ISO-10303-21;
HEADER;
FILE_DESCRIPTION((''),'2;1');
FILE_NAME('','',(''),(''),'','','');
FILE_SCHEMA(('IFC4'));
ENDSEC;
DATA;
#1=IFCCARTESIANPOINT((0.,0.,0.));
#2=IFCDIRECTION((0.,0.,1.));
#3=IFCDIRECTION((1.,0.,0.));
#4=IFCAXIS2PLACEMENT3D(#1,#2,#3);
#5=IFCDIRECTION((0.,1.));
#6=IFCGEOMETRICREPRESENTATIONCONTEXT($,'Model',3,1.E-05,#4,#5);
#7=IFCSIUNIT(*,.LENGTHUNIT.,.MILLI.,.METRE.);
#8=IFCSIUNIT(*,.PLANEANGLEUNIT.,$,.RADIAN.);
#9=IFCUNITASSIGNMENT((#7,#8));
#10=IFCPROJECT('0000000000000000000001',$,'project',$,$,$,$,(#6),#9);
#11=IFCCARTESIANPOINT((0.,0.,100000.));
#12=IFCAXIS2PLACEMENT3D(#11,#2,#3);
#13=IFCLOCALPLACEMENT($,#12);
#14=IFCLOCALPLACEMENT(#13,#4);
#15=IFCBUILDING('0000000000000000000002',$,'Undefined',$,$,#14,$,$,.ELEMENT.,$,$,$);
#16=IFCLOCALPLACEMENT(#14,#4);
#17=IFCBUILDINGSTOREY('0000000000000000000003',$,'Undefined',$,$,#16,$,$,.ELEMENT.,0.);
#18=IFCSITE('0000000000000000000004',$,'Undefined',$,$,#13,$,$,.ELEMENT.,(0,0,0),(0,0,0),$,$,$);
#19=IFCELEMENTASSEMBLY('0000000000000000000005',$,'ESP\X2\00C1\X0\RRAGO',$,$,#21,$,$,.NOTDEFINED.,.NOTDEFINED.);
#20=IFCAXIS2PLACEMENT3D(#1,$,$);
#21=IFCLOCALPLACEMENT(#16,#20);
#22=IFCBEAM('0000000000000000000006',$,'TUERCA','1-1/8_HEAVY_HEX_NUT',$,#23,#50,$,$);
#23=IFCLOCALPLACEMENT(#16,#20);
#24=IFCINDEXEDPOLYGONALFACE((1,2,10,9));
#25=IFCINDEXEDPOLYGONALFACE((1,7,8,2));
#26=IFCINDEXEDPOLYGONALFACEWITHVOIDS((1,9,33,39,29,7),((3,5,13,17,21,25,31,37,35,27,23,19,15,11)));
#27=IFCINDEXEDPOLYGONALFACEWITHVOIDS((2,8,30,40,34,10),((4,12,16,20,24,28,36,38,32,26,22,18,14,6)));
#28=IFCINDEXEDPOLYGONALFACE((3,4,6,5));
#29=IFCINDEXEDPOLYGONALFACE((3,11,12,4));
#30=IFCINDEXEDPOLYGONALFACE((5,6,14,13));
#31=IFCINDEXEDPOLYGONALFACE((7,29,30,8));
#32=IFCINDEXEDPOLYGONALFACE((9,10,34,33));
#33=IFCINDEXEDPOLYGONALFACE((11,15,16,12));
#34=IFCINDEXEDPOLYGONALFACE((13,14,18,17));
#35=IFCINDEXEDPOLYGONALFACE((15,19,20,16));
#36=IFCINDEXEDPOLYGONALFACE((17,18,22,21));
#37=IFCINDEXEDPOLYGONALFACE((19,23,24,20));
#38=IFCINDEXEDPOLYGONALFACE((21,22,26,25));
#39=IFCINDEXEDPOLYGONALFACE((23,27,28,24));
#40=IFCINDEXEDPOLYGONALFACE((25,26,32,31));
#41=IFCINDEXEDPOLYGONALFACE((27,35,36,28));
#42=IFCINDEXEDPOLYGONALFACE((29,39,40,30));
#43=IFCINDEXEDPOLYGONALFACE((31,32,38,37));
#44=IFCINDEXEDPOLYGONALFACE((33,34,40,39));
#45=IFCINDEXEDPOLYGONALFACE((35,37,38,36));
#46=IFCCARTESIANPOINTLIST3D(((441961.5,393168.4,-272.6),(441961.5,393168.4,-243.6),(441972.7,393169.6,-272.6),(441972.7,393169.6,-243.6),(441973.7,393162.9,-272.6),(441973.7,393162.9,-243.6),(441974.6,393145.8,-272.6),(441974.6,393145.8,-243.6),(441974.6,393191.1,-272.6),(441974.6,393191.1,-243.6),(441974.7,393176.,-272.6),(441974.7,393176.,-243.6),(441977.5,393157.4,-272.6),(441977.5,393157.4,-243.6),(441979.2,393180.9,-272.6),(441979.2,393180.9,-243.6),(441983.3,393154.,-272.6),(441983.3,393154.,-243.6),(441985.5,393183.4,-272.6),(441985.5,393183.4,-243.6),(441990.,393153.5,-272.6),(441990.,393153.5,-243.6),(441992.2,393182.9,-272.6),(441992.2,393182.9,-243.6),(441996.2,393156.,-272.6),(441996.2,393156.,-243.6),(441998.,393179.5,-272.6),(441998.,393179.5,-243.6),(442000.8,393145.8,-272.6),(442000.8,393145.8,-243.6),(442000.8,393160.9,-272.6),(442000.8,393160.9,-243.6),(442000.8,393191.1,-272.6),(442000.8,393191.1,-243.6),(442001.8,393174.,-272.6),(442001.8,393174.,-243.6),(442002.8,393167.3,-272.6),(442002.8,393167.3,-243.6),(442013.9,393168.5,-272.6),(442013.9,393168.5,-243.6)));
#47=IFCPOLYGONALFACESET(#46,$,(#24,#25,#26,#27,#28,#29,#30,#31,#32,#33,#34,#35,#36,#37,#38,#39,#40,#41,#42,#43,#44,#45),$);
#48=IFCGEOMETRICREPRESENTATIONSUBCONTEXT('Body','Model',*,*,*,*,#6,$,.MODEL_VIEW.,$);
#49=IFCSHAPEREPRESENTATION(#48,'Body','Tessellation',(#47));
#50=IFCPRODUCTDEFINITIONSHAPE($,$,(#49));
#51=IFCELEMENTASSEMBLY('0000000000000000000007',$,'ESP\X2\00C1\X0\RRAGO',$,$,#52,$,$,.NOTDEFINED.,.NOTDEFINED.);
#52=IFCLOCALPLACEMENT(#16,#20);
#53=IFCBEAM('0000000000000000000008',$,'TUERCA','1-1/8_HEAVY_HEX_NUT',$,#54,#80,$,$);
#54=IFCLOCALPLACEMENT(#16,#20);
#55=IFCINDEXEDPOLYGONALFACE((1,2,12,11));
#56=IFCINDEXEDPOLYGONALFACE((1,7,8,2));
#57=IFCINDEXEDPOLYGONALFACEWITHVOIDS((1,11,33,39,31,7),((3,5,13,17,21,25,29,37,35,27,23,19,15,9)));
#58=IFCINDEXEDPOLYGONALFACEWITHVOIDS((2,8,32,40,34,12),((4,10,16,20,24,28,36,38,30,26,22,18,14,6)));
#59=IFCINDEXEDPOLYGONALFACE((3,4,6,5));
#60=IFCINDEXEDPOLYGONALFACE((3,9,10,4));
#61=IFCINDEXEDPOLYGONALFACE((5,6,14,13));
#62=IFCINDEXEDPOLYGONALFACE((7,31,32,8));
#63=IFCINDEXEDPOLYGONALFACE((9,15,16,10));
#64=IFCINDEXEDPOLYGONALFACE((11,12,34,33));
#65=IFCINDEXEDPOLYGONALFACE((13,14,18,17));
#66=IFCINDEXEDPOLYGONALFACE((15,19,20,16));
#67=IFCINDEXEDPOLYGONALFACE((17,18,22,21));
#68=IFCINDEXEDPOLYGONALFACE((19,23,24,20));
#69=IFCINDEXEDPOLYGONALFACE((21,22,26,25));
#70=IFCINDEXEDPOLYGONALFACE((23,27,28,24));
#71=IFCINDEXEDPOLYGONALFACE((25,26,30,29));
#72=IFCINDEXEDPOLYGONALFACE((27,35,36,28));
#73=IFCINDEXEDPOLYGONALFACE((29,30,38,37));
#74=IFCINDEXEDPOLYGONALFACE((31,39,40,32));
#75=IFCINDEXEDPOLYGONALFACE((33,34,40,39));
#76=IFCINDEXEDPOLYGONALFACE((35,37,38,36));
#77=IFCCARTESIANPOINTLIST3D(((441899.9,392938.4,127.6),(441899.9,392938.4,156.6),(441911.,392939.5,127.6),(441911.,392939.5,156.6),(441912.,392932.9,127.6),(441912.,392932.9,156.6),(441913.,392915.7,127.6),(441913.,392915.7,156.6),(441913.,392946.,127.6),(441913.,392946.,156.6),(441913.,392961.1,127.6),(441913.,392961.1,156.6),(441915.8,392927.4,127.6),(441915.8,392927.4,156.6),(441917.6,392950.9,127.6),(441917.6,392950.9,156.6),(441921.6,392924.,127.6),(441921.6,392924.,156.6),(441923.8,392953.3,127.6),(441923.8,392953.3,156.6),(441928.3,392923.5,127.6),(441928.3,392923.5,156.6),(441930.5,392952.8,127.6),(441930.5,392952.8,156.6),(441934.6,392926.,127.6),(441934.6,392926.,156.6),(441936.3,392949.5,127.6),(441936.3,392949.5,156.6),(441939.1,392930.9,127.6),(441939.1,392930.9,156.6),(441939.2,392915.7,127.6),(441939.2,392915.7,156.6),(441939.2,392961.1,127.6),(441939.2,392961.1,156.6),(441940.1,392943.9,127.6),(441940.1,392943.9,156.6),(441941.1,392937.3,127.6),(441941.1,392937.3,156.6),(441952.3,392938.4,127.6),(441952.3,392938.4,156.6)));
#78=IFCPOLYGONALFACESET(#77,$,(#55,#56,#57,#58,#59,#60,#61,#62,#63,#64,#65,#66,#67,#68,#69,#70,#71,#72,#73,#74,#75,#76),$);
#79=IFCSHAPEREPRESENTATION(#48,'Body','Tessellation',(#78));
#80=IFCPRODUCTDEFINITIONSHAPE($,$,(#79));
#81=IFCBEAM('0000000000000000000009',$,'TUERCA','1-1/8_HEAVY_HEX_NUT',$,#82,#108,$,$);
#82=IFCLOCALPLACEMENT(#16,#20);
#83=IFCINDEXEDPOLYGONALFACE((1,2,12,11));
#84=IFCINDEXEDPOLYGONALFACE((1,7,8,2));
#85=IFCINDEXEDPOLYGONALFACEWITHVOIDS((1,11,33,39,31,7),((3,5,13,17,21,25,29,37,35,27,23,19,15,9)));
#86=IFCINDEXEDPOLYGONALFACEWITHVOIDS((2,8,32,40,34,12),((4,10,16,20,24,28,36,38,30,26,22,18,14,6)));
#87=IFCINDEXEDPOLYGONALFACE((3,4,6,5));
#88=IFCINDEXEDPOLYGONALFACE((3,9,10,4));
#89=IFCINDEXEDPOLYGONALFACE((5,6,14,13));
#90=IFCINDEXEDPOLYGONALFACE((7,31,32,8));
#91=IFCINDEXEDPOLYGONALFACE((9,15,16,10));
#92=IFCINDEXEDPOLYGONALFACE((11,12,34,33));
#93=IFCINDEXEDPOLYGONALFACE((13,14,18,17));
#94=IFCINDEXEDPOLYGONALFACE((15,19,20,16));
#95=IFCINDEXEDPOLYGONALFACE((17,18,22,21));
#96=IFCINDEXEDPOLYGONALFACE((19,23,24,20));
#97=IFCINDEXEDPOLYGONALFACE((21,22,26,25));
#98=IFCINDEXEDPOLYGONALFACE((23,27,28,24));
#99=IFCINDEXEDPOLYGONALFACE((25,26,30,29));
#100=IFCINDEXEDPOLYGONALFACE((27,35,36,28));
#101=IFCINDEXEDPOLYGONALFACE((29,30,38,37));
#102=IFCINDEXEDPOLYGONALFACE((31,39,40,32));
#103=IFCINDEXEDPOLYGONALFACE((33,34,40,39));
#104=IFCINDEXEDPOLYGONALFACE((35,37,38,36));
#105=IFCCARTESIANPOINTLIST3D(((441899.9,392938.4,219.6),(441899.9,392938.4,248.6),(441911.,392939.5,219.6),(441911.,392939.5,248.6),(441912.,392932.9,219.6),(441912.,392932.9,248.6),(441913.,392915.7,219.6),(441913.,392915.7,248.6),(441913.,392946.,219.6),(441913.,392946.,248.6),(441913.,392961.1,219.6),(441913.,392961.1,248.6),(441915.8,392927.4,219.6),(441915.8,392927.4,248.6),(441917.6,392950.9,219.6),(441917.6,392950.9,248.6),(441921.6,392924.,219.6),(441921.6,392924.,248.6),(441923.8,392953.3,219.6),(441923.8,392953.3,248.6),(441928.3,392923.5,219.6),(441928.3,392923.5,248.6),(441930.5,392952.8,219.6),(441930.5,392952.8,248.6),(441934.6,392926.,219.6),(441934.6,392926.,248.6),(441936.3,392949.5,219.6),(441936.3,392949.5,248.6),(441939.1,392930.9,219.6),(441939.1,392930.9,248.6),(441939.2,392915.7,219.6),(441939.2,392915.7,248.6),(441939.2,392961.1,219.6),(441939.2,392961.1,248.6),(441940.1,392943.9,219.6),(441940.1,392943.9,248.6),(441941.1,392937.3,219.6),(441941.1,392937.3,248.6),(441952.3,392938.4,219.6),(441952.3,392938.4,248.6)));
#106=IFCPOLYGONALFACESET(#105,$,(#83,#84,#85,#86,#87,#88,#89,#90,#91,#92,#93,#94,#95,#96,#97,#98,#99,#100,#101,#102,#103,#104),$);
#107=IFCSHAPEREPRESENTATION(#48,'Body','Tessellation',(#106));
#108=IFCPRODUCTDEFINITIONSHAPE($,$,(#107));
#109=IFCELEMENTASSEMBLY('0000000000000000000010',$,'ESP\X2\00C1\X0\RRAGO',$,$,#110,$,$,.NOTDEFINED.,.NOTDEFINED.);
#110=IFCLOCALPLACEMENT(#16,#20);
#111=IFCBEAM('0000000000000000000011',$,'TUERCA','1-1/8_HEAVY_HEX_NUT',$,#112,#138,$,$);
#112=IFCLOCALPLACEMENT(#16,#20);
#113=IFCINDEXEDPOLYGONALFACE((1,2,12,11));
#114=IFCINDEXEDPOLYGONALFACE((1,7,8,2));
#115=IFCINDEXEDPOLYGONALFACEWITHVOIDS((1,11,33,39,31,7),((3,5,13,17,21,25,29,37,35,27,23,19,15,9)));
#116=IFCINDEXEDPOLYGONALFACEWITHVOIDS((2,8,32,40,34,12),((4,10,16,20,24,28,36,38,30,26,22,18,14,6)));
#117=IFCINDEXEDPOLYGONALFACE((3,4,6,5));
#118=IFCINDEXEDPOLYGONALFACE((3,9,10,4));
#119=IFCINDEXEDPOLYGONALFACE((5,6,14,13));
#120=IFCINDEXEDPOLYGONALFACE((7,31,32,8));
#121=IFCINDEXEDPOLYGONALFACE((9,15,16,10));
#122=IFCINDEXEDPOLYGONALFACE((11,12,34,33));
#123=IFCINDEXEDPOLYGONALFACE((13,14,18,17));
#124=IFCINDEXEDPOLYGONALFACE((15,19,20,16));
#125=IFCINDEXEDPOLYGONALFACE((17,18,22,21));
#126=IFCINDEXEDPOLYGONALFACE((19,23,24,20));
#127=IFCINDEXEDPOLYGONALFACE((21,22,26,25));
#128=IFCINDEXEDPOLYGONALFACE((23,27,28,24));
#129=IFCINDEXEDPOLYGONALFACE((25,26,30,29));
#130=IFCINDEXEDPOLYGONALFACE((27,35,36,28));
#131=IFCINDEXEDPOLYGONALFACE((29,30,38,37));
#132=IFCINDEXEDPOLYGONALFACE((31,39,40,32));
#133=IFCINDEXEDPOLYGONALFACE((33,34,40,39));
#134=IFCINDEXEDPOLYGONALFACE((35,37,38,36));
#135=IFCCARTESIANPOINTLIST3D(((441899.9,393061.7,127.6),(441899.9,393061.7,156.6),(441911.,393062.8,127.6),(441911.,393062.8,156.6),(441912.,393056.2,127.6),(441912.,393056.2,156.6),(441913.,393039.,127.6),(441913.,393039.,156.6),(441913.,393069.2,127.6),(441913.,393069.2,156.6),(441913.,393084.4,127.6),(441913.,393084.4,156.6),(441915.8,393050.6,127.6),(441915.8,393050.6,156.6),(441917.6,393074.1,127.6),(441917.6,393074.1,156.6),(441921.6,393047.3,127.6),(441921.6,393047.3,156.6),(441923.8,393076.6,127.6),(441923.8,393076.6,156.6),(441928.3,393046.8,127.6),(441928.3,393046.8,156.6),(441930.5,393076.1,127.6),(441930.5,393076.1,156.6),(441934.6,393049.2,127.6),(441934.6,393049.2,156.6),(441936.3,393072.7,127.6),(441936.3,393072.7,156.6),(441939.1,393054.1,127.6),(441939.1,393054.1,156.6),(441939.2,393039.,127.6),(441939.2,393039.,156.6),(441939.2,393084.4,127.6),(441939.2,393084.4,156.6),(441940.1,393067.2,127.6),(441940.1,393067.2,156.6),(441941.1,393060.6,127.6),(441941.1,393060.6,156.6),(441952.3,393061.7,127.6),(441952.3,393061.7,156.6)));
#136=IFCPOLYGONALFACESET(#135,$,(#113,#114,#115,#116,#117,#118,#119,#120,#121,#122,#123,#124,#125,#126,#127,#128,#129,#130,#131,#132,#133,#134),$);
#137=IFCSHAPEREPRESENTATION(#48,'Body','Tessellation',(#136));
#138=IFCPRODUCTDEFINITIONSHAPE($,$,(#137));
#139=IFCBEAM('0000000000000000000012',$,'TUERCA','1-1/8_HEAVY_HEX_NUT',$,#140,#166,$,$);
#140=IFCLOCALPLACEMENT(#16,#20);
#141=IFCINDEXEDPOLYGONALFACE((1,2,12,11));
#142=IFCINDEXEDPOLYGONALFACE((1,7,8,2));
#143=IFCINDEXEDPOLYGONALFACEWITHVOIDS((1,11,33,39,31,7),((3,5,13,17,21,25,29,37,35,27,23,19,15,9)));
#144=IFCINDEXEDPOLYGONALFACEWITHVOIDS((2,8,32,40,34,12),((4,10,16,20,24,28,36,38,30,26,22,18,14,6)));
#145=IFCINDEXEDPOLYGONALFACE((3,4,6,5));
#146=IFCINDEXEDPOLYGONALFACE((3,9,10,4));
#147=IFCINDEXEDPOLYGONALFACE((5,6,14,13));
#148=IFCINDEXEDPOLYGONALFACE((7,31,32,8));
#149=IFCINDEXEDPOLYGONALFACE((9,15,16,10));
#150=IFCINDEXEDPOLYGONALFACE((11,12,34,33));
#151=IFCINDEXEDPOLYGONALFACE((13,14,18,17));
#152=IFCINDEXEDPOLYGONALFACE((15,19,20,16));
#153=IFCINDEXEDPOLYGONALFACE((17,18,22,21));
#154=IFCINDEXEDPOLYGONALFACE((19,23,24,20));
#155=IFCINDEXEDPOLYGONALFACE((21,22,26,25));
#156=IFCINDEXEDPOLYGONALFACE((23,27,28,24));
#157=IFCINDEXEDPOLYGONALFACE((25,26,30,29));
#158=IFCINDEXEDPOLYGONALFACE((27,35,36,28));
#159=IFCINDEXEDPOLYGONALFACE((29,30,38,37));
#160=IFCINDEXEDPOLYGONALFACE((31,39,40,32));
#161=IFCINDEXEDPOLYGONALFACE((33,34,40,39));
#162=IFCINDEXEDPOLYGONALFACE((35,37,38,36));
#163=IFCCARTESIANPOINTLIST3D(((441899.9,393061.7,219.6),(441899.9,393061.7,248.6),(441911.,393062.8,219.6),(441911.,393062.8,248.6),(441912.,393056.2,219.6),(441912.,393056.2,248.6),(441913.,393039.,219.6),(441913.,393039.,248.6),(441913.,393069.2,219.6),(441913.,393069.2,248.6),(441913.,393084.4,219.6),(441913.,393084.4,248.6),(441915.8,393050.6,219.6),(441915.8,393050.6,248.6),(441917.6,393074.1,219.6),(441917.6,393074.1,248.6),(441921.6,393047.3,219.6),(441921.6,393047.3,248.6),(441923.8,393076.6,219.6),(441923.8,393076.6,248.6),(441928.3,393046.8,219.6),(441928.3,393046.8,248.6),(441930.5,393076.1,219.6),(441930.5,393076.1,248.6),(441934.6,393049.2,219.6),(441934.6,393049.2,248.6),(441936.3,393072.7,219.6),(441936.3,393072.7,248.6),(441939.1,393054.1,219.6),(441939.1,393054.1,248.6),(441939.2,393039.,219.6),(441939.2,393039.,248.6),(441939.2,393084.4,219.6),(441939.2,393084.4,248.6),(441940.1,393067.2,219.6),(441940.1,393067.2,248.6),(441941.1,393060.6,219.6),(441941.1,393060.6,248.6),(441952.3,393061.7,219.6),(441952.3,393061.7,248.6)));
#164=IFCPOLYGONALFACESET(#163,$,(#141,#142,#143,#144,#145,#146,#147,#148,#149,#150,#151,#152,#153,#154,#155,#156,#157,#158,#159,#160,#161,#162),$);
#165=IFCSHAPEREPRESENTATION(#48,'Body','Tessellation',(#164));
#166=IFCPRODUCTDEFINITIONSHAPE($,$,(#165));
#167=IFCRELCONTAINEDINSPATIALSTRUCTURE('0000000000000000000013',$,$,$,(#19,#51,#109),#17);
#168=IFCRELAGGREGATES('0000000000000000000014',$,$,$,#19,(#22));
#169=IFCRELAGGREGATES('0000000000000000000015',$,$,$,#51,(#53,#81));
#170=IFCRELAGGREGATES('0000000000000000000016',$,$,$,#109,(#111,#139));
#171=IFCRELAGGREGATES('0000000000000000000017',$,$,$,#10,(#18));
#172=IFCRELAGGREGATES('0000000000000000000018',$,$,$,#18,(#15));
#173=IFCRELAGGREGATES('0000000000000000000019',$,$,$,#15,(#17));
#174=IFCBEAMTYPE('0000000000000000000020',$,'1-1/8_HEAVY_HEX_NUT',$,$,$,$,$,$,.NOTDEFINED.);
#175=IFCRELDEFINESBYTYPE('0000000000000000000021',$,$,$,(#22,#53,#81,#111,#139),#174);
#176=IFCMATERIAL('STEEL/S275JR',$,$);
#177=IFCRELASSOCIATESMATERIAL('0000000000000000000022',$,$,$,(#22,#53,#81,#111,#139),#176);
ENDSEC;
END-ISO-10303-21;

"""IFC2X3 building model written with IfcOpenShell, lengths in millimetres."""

from ifc_helpers import new_model, si_unit, direction, frame, origin_with_axes, place, context, subcontext, project, spatial, polyline, outline, extrude, material, type_object, element, aggregate, save


model = new_model("IFC2X3")

# Units and contexts
model_context = context("Model", 3, precision=1e-05, world=origin_with_axes(), true_north=direction((0.0, 1.0)))
body_context = subcontext(model_context, "Body", "Model", "MODEL_VIEW")
ifc_project = project(units=[si_unit("LENGTHUNIT", "METRE", prefix="MILLI"), si_unit("PLANEANGLEUNIT", "RADIAN")], contexts=[model_context])

# Site, building, storey
site_placement = place(None, frame((0.0, 0.0, 100000.0), z_axis=(0.0, 0.0, 1.0), x_axis=(1.0, 0.0, 0.0)))
site = spatial("IfcSite", under=ifc_project, at=site_placement, Name="Undefined", CompositionType="ELEMENT", RefLatitude=(0, 0, 0), RefLongitude=(0, 0, 0))
building_placement = place(site_placement, origin_with_axes())
building = spatial("IfcBuilding", under=site, at=building_placement, Name="Undefined", CompositionType="ELEMENT")
storey_placement = place(building_placement, origin_with_axes())
storey = spatial("IfcBuildingStorey", under=building, at=storey_placement, Name="Undefined", CompositionType="ELEMENT", Elevation=0.0)

# Element assembly
ifc_material_1 = material(Name="STEEL/S275JR")
beam_type_1 = type_object("IfcBeamType", Name="1-1/8_HEAVY_HEX_NUT", PredefinedType="NOTDEFINED")
assembly_1_placement = place(storey_placement, origin_with_axes())
assembly_1 = element("IfcElementAssembly", 1, at=assembly_1_placement, inside=storey, Name="ESPÁRRAGO", AssemblyPlace="NOTDEFINED", PredefinedType="NOTDEFINED")

# Beam
beam_1_placement = place(assembly_1_placement, frame((441987.7, 393168.4, -243.6), z_axis=(0.866025, -0.5, 0.0), x_axis=(0.0, 0.0, -1.0)))
beam_1 = element("IfcBeam", 2, at=beam_1_placement, type_object=beam_type_1, material=ifc_material_1, Name="TUERCA", Description="1-1/8_HEAVY_HEX_NUT", context=body_context, shape_type="SweptSolid", body=[
    extrude(outline(polyline([(-13.1, -22.7), (-26.2, 0.0), (-13.1, 22.7), (13.1, 22.7), (26.2, 0.0), (13.1, -22.7), (-13.1, -22.7)]), holes=[polyline([(6.5, 13.6), (0.0, 15.1), (-6.5, 13.6), (-11.8, 9.4), (-14.7, 3.4), (-14.7, -3.4), (-11.8, -9.4), (-6.5, -13.6), (0.0, -15.1), (6.5, -13.6), (11.8, -9.4), (14.7, -3.4), (14.7, 3.4), (11.8, 9.4), (6.5, 13.6)])]), frame((29.0, 0.0, 0.0), z_axis=(-1.0, 0.0, 0.0), x_axis=(0.0, -1.0, 0.0)), (0.0, 0.0, 1.0), 29.0),
])

# Element assemblies, beams
assembly_2_placement = place(storey_placement, origin_with_axes())
assembly_2 = element("IfcElementAssembly", 3, at=assembly_2_placement, inside=storey, Name="ESPÁRRAGO", AssemblyPlace="NOTDEFINED", PredefinedType="NOTDEFINED")
beam_2_placement = place(assembly_2_placement, frame((441926.1, 392938.4, 156.6), z_axis=(0.866025, -0.5, 0.0), x_axis=(0.0, 0.0, -1.0)))
beam_2 = element("IfcBeam", 4, at=beam_2_placement, type_object=beam_type_1, material=ifc_material_1, Name="TUERCA", Description="1-1/8_HEAVY_HEX_NUT", context=body_context, shape_type="SweptSolid", body=[
    extrude(outline(polyline([(-13.1, -22.7), (-26.2, 0.0), (-13.1, 22.7), (13.1, 22.7), (26.2, 0.0), (13.1, -22.7), (-13.1, -22.7)]), holes=[polyline([(6.5, 13.6), (0.0, 15.1), (-6.5, 13.6), (-11.8, 9.4), (-14.7, 3.4), (-14.7, -3.4), (-11.8, -9.4), (-6.5, -13.6), (0.0, -15.1), (6.5, -13.6), (11.8, -9.4), (14.7, -3.4), (14.7, 3.4), (11.8, 9.4), (6.5, 13.6)])]), frame((29.0, 0.0, 0.0), z_axis=(-1.0, 0.0, 0.0), x_axis=(0.0, -1.0, 0.0)), (0.0, 0.0, 1.0), 29.0),
])
beam_3_placement = place(assembly_2_placement, frame((441926.1, 392938.4, 248.6), z_axis=(0.866025, -0.5, 0.0), x_axis=(0.0, 0.0, -1.0)))
beam_3 = element("IfcBeam", 5, at=beam_3_placement, type_object=beam_type_1, material=ifc_material_1, Name="TUERCA", Description="1-1/8_HEAVY_HEX_NUT", context=body_context, shape_type="SweptSolid", body=[
    extrude(outline(polyline([(-13.1, -22.7), (-26.2, 0.0), (-13.1, 22.7), (13.1, 22.7), (26.2, 0.0), (13.1, -22.7), (-13.1, -22.7)]), holes=[polyline([(6.5, 13.6), (0.0, 15.1), (-6.5, 13.6), (-11.8, 9.4), (-14.7, 3.4), (-14.7, -3.4), (-11.8, -9.4), (-6.5, -13.6), (0.0, -15.1), (6.5, -13.6), (11.8, -9.4), (14.7, -3.4), (14.7, 3.4), (11.8, 9.4), (6.5, 13.6)])]), frame((29.0, 0.0, 0.0), z_axis=(-1.0, 0.0, 0.0), x_axis=(0.0, -1.0, 0.0)), (0.0, 0.0, 1.0), 29.0),
])
assembly_3_placement = place(storey_placement, origin_with_axes())
assembly_3 = element("IfcElementAssembly", 6, at=assembly_3_placement, inside=storey, Name="ESPÁRRAGO", AssemblyPlace="NOTDEFINED", PredefinedType="NOTDEFINED")
beam_4_placement = place(assembly_3_placement, frame((441926.1, 393061.7, 156.6), z_axis=(0.866025, -0.5, 0.0), x_axis=(0.0, 0.0, -1.0)))
beam_4 = element("IfcBeam", 7, at=beam_4_placement, type_object=beam_type_1, material=ifc_material_1, Name="TUERCA", Description="1-1/8_HEAVY_HEX_NUT", context=body_context, shape_type="SweptSolid", body=[
    extrude(outline(polyline([(-13.1, -22.7), (-26.2, 0.0), (-13.1, 22.7), (13.1, 22.7), (26.2, 0.0), (13.1, -22.7), (-13.1, -22.7)]), holes=[polyline([(6.5, 13.6), (0.0, 15.1), (-6.5, 13.6), (-11.8, 9.4), (-14.7, 3.4), (-14.7, -3.4), (-11.8, -9.4), (-6.5, -13.6), (0.0, -15.1), (6.5, -13.6), (11.8, -9.4), (14.7, -3.4), (14.7, 3.4), (11.8, 9.4), (6.5, 13.6)])]), frame((29.0, 0.0, 0.0), z_axis=(-1.0, 0.0, 0.0), x_axis=(0.0, -1.0, 0.0)), (0.0, 0.0, 1.0), 29.0),
])
beam_5_placement = place(assembly_3_placement, frame((441926.1, 393061.7, 248.6), z_axis=(0.866025, -0.5, 0.0), x_axis=(0.0, 0.0, -1.0)))
beam_5 = element("IfcBeam", 8, at=beam_5_placement, type_object=beam_type_1, material=ifc_material_1, Name="TUERCA", Description="1-1/8_HEAVY_HEX_NUT", context=body_context, shape_type="SweptSolid", body=[
    extrude(outline(polyline([(-13.1, -22.7), (-26.2, 0.0), (-13.1, 22.7), (13.1, 22.7), (26.2, 0.0), (13.1, -22.7), (-13.1, -22.7)]), holes=[polyline([(6.5, 13.6), (0.0, 15.1), (-6.5, 13.6), (-11.8, 9.4), (-14.7, 3.4), (-14.7, -3.4), (-11.8, -9.4), (-6.5, -13.6), (0.0, -15.1), (6.5, -13.6), (11.8, -9.4), (14.7, -3.4), (14.7, 3.4), (11.8, 9.4), (6.5, 13.6)])]), frame((29.0, 0.0, 0.0), z_axis=(-1.0, 0.0, 0.0), x_axis=(0.0, -1.0, 0.0)), (0.0, 0.0, 1.0), 29.0),
])

aggregate(assembly_1, [beam_1])
aggregate(assembly_2, [beam_2, beam_3])
aggregate(assembly_3, [beam_4, beam_5])

save(model, "model.ifc")
